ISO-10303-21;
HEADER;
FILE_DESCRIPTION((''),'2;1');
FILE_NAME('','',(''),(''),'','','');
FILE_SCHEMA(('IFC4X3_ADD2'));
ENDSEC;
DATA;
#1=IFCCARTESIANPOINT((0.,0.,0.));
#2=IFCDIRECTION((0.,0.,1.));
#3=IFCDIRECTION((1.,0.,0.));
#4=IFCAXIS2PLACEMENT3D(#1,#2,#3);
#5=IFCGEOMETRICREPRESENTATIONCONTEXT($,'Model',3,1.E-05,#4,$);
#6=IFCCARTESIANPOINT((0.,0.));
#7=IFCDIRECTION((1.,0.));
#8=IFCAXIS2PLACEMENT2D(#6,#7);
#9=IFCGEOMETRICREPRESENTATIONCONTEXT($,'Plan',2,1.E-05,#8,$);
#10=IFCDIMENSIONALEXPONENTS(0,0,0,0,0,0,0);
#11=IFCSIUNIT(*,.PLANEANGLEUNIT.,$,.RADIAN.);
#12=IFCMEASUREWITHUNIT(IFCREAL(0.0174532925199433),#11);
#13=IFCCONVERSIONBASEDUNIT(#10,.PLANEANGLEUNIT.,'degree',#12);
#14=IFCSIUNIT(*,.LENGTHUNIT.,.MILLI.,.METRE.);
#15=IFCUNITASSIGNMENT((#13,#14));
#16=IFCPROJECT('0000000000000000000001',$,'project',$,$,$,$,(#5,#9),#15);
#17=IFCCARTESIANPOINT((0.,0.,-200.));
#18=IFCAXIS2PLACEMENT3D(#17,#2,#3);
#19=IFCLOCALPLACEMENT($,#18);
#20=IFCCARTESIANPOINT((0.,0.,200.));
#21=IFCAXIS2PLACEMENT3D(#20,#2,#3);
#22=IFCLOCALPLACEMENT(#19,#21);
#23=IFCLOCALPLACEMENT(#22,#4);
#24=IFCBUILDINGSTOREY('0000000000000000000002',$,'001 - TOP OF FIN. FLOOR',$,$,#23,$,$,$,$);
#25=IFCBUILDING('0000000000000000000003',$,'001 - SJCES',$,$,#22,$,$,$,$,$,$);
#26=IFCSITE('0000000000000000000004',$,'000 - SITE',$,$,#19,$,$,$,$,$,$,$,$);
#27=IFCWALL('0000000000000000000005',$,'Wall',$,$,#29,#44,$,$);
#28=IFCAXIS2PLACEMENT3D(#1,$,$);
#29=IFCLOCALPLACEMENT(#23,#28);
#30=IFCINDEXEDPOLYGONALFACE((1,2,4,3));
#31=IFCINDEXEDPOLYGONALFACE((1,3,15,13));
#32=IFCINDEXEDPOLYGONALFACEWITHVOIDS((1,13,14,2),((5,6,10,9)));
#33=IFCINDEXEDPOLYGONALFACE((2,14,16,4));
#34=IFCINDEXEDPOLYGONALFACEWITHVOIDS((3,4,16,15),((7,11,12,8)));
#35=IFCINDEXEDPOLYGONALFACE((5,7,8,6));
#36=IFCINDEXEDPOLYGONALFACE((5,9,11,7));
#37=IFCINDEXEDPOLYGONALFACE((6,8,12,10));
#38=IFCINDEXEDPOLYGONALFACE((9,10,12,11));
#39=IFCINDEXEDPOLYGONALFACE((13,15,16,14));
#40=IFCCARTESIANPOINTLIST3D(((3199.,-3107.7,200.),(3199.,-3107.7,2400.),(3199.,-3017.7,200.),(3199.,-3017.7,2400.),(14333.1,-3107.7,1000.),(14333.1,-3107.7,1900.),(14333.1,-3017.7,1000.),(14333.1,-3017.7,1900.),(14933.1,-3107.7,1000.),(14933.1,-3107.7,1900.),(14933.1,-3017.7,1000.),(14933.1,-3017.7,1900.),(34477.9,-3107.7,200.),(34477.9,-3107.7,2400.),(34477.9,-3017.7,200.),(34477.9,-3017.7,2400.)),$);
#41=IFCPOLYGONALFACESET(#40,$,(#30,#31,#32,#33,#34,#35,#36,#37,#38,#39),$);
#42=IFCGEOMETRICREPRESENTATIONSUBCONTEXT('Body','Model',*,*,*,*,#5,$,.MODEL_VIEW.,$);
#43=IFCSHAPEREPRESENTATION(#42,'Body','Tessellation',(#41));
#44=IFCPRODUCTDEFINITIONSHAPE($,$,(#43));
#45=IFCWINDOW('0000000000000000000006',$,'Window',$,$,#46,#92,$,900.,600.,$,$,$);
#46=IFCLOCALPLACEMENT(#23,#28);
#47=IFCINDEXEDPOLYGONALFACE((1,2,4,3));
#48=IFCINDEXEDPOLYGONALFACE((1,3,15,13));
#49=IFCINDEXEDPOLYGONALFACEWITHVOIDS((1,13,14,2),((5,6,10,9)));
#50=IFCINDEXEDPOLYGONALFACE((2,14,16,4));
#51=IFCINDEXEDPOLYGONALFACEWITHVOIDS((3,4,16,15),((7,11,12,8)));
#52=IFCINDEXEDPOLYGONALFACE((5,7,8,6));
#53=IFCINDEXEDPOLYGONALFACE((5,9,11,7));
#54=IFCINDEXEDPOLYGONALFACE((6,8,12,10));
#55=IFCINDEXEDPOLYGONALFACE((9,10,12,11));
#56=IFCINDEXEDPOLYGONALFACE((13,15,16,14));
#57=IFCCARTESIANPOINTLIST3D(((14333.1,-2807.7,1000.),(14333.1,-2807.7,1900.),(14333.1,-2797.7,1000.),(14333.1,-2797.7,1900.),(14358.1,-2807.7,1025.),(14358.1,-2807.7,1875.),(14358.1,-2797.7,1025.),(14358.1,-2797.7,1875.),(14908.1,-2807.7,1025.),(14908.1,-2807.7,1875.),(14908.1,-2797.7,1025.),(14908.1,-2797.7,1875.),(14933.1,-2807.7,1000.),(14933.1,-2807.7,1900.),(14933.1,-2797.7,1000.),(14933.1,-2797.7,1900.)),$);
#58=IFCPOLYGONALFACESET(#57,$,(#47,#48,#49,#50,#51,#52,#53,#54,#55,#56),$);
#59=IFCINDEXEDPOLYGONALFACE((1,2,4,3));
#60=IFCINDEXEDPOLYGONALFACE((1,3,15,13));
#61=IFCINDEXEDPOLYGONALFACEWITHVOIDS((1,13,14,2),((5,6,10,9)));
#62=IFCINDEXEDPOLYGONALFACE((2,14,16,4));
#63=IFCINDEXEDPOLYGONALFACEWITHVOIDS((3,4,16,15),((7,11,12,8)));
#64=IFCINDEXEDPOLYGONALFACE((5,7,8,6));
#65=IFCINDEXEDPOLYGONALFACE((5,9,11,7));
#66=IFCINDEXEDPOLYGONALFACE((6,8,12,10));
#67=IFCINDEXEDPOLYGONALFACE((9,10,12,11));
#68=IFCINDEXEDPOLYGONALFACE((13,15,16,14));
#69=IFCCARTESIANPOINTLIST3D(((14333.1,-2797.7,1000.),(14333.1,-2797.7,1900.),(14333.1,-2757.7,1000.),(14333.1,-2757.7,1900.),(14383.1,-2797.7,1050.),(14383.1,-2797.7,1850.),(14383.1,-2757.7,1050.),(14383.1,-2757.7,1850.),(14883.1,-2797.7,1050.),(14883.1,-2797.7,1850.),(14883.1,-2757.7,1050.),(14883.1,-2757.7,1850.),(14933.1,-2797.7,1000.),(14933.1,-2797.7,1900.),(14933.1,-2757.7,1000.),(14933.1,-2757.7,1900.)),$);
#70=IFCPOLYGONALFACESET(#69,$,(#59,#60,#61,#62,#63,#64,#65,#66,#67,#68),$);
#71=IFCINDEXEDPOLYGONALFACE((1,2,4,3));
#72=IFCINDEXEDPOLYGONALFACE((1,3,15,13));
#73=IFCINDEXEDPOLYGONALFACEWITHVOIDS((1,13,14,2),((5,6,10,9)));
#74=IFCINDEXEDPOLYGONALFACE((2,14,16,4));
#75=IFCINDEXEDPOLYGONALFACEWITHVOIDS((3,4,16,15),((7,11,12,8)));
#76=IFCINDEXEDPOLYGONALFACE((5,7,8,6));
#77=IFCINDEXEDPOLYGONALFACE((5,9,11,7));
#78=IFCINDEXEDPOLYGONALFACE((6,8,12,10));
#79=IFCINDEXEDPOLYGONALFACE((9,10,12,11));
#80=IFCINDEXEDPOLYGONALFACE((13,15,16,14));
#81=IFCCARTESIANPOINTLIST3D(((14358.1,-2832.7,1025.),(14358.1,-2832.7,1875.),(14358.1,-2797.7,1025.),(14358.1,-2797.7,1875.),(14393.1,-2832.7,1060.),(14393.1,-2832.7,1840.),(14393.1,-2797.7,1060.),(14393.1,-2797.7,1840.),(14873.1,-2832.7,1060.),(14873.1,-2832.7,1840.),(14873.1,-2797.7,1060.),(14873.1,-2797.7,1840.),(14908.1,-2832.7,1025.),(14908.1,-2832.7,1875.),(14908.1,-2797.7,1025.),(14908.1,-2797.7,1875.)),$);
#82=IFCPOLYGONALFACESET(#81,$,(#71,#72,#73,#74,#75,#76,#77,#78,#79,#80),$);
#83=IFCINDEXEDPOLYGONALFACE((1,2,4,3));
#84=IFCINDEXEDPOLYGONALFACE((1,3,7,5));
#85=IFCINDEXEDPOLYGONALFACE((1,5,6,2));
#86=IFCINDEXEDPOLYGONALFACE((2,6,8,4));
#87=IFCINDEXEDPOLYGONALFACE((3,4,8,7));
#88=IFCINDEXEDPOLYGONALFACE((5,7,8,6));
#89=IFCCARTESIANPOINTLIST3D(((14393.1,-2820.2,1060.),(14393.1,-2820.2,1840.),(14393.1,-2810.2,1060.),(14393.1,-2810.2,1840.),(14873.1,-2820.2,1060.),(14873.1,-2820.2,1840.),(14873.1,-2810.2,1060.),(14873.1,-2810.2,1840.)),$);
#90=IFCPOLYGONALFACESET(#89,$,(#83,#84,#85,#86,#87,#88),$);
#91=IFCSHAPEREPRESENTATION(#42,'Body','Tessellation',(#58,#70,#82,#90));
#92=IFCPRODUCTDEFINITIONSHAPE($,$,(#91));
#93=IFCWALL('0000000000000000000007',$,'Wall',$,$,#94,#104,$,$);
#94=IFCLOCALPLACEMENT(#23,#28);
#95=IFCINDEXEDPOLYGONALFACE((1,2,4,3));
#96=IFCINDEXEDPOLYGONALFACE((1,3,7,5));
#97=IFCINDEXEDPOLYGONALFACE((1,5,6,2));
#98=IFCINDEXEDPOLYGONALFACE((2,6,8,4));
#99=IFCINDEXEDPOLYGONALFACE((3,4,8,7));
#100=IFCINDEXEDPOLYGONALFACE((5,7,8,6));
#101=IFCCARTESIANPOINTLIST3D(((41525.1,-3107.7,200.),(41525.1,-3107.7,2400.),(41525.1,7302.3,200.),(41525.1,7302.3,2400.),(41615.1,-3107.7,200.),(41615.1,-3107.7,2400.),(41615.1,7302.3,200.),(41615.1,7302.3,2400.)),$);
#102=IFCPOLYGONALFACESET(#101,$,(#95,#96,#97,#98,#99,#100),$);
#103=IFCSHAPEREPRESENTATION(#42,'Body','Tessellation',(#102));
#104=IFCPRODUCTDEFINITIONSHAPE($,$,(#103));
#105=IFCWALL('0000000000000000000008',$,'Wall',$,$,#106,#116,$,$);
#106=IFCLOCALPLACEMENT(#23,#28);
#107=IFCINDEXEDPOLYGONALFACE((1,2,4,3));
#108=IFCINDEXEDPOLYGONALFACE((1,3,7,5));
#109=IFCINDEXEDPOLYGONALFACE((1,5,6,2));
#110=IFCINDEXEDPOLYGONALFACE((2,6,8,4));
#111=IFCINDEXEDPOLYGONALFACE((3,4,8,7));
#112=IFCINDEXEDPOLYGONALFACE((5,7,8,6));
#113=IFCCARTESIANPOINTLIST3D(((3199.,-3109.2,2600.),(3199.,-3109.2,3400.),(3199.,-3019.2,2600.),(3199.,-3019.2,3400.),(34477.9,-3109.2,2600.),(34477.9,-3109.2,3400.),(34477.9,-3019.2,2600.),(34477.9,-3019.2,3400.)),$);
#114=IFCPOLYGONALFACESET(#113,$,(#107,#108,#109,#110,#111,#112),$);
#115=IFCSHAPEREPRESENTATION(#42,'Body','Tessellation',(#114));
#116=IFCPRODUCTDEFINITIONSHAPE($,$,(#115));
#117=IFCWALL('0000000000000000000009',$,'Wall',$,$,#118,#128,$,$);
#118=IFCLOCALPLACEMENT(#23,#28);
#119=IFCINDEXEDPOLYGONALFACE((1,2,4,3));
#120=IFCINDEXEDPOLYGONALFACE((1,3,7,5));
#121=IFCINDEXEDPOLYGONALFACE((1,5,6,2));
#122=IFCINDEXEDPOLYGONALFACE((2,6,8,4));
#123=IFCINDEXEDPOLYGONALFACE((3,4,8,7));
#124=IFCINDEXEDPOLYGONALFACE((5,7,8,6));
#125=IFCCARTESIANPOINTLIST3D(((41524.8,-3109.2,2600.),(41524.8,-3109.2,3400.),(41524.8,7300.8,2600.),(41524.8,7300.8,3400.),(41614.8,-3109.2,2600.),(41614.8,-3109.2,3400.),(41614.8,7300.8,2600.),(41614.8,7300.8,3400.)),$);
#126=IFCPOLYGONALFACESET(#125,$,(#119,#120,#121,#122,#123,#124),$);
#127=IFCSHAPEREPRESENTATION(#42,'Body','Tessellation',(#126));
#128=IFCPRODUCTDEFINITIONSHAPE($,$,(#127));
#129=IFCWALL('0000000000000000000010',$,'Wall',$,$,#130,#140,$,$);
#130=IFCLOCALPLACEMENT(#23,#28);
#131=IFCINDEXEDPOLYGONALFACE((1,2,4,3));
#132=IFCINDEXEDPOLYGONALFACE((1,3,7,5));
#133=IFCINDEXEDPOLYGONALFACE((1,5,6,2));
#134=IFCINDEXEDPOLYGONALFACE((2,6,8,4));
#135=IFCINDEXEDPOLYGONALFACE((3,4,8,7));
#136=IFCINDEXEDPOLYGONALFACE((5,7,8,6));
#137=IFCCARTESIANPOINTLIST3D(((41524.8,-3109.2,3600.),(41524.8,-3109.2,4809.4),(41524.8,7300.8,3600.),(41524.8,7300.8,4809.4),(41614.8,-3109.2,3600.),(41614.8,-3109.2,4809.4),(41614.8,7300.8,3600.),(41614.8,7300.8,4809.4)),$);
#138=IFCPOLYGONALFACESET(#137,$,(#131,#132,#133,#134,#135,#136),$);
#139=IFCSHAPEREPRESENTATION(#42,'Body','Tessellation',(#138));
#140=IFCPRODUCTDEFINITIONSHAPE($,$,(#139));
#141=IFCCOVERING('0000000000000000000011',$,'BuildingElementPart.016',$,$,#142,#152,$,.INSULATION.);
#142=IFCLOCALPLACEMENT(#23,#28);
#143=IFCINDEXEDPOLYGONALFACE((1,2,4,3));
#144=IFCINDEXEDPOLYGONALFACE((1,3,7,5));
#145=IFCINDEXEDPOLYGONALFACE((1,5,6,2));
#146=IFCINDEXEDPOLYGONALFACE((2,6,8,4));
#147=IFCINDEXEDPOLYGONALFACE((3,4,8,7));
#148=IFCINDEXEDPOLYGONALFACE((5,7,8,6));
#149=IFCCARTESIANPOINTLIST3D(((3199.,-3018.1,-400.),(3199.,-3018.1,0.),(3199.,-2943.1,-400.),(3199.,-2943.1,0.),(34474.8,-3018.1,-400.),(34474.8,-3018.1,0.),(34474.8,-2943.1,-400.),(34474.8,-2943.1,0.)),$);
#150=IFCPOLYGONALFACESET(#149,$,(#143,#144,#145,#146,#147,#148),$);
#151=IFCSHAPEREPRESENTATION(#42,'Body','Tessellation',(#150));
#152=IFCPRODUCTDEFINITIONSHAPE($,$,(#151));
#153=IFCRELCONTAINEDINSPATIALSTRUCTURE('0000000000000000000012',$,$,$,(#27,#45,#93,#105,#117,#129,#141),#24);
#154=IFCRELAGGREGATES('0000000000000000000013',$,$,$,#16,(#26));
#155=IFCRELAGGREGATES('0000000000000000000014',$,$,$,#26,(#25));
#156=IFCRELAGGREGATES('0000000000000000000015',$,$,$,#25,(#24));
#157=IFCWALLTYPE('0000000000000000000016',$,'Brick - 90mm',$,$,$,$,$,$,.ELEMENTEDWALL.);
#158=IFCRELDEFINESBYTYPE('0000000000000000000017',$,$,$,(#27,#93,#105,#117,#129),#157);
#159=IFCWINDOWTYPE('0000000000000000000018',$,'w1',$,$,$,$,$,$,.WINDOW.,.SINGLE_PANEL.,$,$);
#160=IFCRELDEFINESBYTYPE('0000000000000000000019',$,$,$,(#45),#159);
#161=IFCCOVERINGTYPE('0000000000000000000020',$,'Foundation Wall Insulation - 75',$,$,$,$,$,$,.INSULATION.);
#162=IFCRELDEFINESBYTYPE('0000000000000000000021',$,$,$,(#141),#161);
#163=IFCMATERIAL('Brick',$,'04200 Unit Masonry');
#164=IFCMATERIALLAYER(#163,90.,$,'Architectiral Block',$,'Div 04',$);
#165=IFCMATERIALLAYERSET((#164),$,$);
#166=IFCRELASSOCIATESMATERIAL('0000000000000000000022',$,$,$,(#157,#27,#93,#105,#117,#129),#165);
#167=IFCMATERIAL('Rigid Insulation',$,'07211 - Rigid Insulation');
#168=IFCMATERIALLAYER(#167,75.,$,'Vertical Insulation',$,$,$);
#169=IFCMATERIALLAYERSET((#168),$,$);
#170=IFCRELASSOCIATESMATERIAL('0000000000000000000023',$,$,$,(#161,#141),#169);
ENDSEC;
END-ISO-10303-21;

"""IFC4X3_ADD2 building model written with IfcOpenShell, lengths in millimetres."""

from ifc_helpers import new_model, entity, si_unit, converted_unit, frame, origin_with_axes, origin_2d_with_axis, place, context, subcontext, project, spatial, line, indexed_curve, outline, extrude, shape, source, transform, mapped, material, layer, layer_set, layer_usage, type_object, type_shapes, element, fill, save


model = new_model("IFC4X3_ADD2")

# Units and contexts
model_context = context("Model", 3, precision=1e-05, world=origin_with_axes())
plan_context = context("Plan", 2, precision=1e-05, world=origin_2d_with_axis())
body_context_1 = subcontext(model_context, "Body", "Model", "MODEL_VIEW")
body_context_2 = subcontext(plan_context, "Body", "Plan", "PLAN_VIEW")
ifc_project = project(units=[converted_unit("PLANEANGLEUNIT", "degree", entity("IfcReal", 0.0174532925199433), si_unit("PLANEANGLEUNIT", "RADIAN"), dimensions=[0, 0, 0, 0, 0, 0, 0]), si_unit("LENGTHUNIT", "METRE", prefix="MILLI")], contexts=[model_context, plan_context])

# Site, building, storey
site_placement = place(None, frame((0.0, 0.0, -200.0), z_axis=(0.0, 0.0, 1.0), x_axis=(1.0, 0.0, 0.0)))
site = spatial("IfcSite", under=ifc_project, at=site_placement, Name="000 - SITE")
building_placement = place(site_placement, frame((0.0, 0.0, 200.0), z_axis=(0.0, 0.0, 1.0), x_axis=(1.0, 0.0, 0.0)))
building = spatial("IfcBuilding", under=site, at=building_placement, Name="001 - SJCES")
storey_placement = place(building_placement, origin_with_axes())
storey = spatial("IfcBuildingStorey", under=building, at=storey_placement, Name="001 - TOP OF FIN. FLOOR")

# Wall, openings, window
ifc_material_1 = material(Name="Brick", Category="04200 Unit Masonry")
ifc_layer_1 = layer(ifc_material_1, 90.0, Name="Architectiral Block", Category="Div 04")
ifc_layer_set_1 = layer_set([ifc_layer_1])
ifc_layer_usage_1 = layer_usage(ifc_layer_set_1, "AXIS2", "POSITIVE", 0.0)
wall_type_1 = type_object("IfcWallType", Name="Brick - 90mm", PredefinedType="ELEMENTEDWALL", material=ifc_layer_set_1)
wall_1_placement = place(storey_placement, frame((3199.0, -3107.7, 200.0), z_axis=(0.0, 0.0, 1.0), x_axis=(1.0, 0.0, 0.0)))
wall_1 = element("IfcWall", 1, at=wall_1_placement, inside=storey, type_object=wall_type_1, material=ifc_layer_usage_1, Name="Wall", context=body_context_1, shape_type="SweptSolid", body=[
    extrude(outline(indexed_curve([(0.0, 0.0), (0.0, 90.0), (31278.9, 90.0), (31278.9, 0.0), (0.0, 0.0)], self_intersect=False)), origin_with_axes(), (0.0, 0.0, 1.0), 2200.0),
])
shared_shape_1 = source(origin_with_axes(), body_context_1, "Body", "SweptSolid", [
    extrude(outline(indexed_curve([(0.0, 0.0), (600.0, 0.0), (600.0, 900.0), (0.0, 900.0)], segments=[line(1, 2, 3, 4, 1)])), frame((0.0, -600.0, 0.0), z_axis=(0.0, -1.0, 0.0), x_axis=(1.0, 0.0, 0.0)), (0.0, 0.0, -1.0), 1200.0),
])
opening_1_placement = place(wall_1_placement, frame((11734.1, 400.0, 800.0), z_axis=(0.0, 0.0, 1.0), x_axis=(-1.0, 0.0, 0.0)))
opening_1 = element("IfcOpeningElement", 2, at=opening_1_placement, cuts=wall_1, PredefinedType="OPENING", context=body_context_1, shape_type="MappedRepresentation", body=[
    mapped(shared_shape_1, transform((0.0, 0.0, 0.0), x_axis=(1.0, 0.0, 0.0), y_axis=(0.0, 1.0, 0.0), z_axis=(0.0, 0.0, 1.0), scale=1.0)),
])
covering_1_placement = place(storey_placement, frame((34562.0, -2897.7, 0.0), z_axis=(0.0, 0.0, 1.0), x_axis=(-1.0, 0.0, 0.0)))
opening_2_placement = place(covering_1_placement, frame((19628.9, -190.0, 1000.0), z_axis=(0.0, 0.0, 1.0), x_axis=(1.0, 0.0, 0.0)))
element("IfcOpeningElement", 3, at=opening_2_placement, cuts=wall_1, context=body_context_1, shape_type="MappedRepresentation", body=[
    mapped(shared_shape_1, transform((0.0, 0.0, 0.0), x_axis=(1.0, 0.0, 0.0), y_axis=(0.0, 1.0, 0.0), z_axis=(0.0, 0.0, 1.0), scale=1.0)),
])
window_type = type_object("IfcWindowType", Name="w1", PartitioningType="SINGLE_PANEL", PredefinedType="WINDOW")
shared_shape_2 = source(origin_with_axes(), body_context_1, "Body", "SweptSolid", [
    extrude(outline(indexed_curve([(0.0, 0.0), (600.0, 0.0), (600.0, 900.0), (0.0, 900.0)], segments=[line(1, 2, 3, 4, 1)]), holes=[indexed_curve([(25.0, 25.0), (575.0, 25.0), (575.0, 875.0), (25.0, 875.0)], segments=[line(1, 2, 3, 4, 1)])]), frame((0.0, 90.0, 0.0), z_axis=(0.0, -1.0, 0.0), x_axis=(1.0, 0.0, 0.0)), (0.0, 0.0, -1.0), 10.0),
    extrude(outline(indexed_curve([(0.0, 0.0), (600.0, 0.0), (600.0, 900.0), (0.0, 900.0)], segments=[line(1, 2, 3, 4, 1)]), holes=[indexed_curve([(50.0, 50.0), (550.0, 50.0), (550.0, 850.0), (50.0, 850.0)], segments=[line(1, 2, 3, 4, 1)])]), frame((0.0, 50.0, 0.0), z_axis=(0.0, -1.0, 0.0), x_axis=(1.0, 0.0, 0.0)), (0.0, 0.0, -1.0), 40.0),
    extrude(outline(indexed_curve([(0.0, 0.0), (550.0, 0.0), (550.0, 850.0), (0.0, 850.0)], segments=[line(1, 2, 3, 4, 1)]), holes=[indexed_curve([(35.0, 35.0), (515.0, 35.0), (515.0, 815.0), (35.0, 815.0)], segments=[line(1, 2, 3, 4, 1)])]), frame((25.0, 90.0, 25.0), z_axis=(0.0, -1.0, 0.0), x_axis=(1.0, 0.0, 0.0)), (0.0, 0.0, -1.0), 35.0),
    extrude(outline(indexed_curve([(35.0, 35.0), (515.0, 35.0), (515.0, 815.0), (35.0, 815.0)], segments=[line(1, 2, 3, 4, 1)])), frame((25.0, 102.5, 25.0), z_axis=(0.0, -1.0, 0.0), x_axis=(1.0, 0.0, 0.0)), (0.0, 0.0, -1.0), 10.0),
])
shared_shape_3 = source(origin_with_axes(), body_context_2, "Body", "Curve2D", [
    entity("IfcIndexedPolyCurve", entity("IfcCartesianPointList2D", [[50.0, 50.0], [550.0, 50.0]])),
    entity("IfcIndexedPolyCurve", entity("IfcCartesianPointList2D", [[0.0, 100.0], [25.0, 100.0], [25.0, 90.0], [50.0, 90.0], [50.0, 50.0], [0.0, 50.0]]), [entity("IfcLineIndex", [1, 2, 3, 4, 5, 6, 1])]),
    entity("IfcIndexedPolyCurve", entity("IfcCartesianPointList2D", [[600.0, 100.0], [575.0, 100.0], [575.0, 90.0], [550.0, 90.0], [550.0, 50.0], [600.0, 50.0]]), [entity("IfcLineIndex", [1, 2, 3, 4, 5, 6, 1])]),
    entity("IfcIndexedPolyCurve", entity("IfcCartesianPointList2D", [[25.0, 90.0], [60.0, 90.0], [60.0, 125.0], [25.0, 125.0]]), [entity("IfcLineIndex", [1, 2, 3, 4, 1])]),
    entity("IfcIndexedPolyCurve", entity("IfcCartesianPointList2D", [[575.0, 90.0], [540.0, 90.0], [540.0, 125.0], [575.0, 125.0]]), [entity("IfcLineIndex", [1, 2, 3, 4, 1])]),
    entity("IfcIndexedPolyCurve", entity("IfcCartesianPointList2D", [[60.0, 90.0], [540.0, 90.0]])),
    entity("IfcIndexedPolyCurve", entity("IfcCartesianPointList2D", [[60.0, 125.0], [540.0, 125.0]])),
    entity("IfcIndexedPolyCurve", entity("IfcCartesianPointList2D", [[60.0, 107.5], [540.0, 107.5]])),
])
type_shapes(window_type, [shared_shape_2, shared_shape_3])
window_placement = place(opening_1_placement, frame((0.0, 0.0, 0.0), z_axis=(0.0, 0.0, 1.0), x_axis=(1.0, 0.0, 0.0)))
window = element("IfcWindow", 4, at=window_placement, inside=storey, type_object=window_type, Name="Window", OverallHeight=900.0, OverallWidth=600.0, shapes=[
    shape(body_context_1, "Body", "MappedRepresentation", [mapped(shared_shape_2, transform((0.0, 0.0, 0.0), x_axis=(1.0, 0.0, 0.0), y_axis=(0.0, 1.0, 0.0), z_axis=(0.0, 0.0, 1.0), scale=1.0))]),
    shape(body_context_2, "Body", "MappedRepresentation", [mapped(shared_shape_3, transform((0.0, 0.0, 0.0), x_axis=(1.0, 0.0, 0.0), y_axis=(0.0, 1.0, 0.0), z_axis=(0.0, 0.0, 1.0), scale=1.0))]),
])
fill(opening_1, window)

# Walls
ifc_layer_usage_2 = layer_usage(ifc_layer_set_1, "AXIS2", "POSITIVE", 0.0)
wall_2_placement = place(storey_placement, frame((41615.1, -3107.7, 200.0), z_axis=(0.0, 0.0, 1.0), x_axis=(0.0, 1.0, 0.0)))
element("IfcWall", 5, at=wall_2_placement, inside=storey, type_object=wall_type_1, material=ifc_layer_usage_2, Name="Wall", context=body_context_1, shape_type="SweptSolid", body=[
    extrude(outline(indexed_curve([(0.0, 0.0), (0.0, 90.0), (10410.0, 90.0), (10410.0, 0.0), (0.0, 0.0)], self_intersect=False)), origin_with_axes(), (0.0, 0.0, 1.0), 2200.0),
])
ifc_layer_usage_3 = layer_usage(ifc_layer_set_1, "AXIS2", "POSITIVE", 0.0)
wall_3_placement = place(storey_placement, frame((3199.0, -3109.2, 2600.0), z_axis=(0.0, 0.0, 1.0), x_axis=(1.0, 0.0, 0.0)))
element("IfcWall", 6, at=wall_3_placement, inside=storey, type_object=wall_type_1, material=ifc_layer_usage_3, Name="Wall", context=body_context_1, shape_type="SweptSolid", body=[
    extrude(outline(indexed_curve([(0.0, 0.0), (0.0, 90.0), (31278.9, 90.0), (31278.9, 0.0), (0.0, 0.0)], self_intersect=False)), origin_with_axes(), (0.0, 0.0, 1.0), 800.0),
])
ifc_layer_usage_4 = layer_usage(ifc_layer_set_1, "AXIS2", "POSITIVE", 0.0)
wall_4_placement = place(storey_placement, frame((41614.8, -3109.2, 2600.0), z_axis=(0.0, 0.0, 1.0), x_axis=(0.0, 1.0, 0.0)))
element("IfcWall", 7, at=wall_4_placement, inside=storey, type_object=wall_type_1, material=ifc_layer_usage_4, Name="Wall", context=body_context_1, shape_type="SweptSolid", body=[
    extrude(outline(indexed_curve([(0.0, 0.0), (0.0, 90.0), (10410.0, 90.0), (10410.0, 0.0), (0.0, 0.0)], self_intersect=False)), origin_with_axes(), (0.0, 0.0, 1.0), 800.0),
])
ifc_layer_usage_5 = layer_usage(ifc_layer_set_1, "AXIS2", "POSITIVE", 0.0)
wall_5_placement = place(storey_placement, frame((41614.8, -3109.2, 3600.0), z_axis=(0.0, 0.0, 1.0), x_axis=(0.0, 1.0, 0.0)))
element("IfcWall", 8, at=wall_5_placement, inside=storey, type_object=wall_type_1, material=ifc_layer_usage_5, Name="Wall", context=body_context_1, shape_type="SweptSolid", body=[
    extrude(outline(indexed_curve([(0.0, 0.0), (0.0, 90.0), (10410.0, 90.0), (10410.0, 0.0), (0.0, 0.0)], self_intersect=False)), origin_with_axes(), (0.0, 0.0, 1.0), 1209.4),
])

# Covering
ifc_material_2 = material(Name="Rigid Insulation", Category="07211 - Rigid Insulation")
ifc_layer_2 = layer(ifc_material_2, 75.0, Name="Vertical Insulation")
ifc_layer_set_2 = layer_set([ifc_layer_2])
ifc_layer_usage_6 = layer_usage(ifc_layer_set_2, "AXIS2", "POSITIVE", 0.0)
covering_type_1 = type_object("IfcCoveringType", Name="Foundation Wall Insulation - 75", PredefinedType="INSULATION", material=ifc_layer_set_2)
covering_2_placement = place(storey_placement, frame((3199.0, -3018.1, -400.0), z_axis=(0.0, 0.0, 1.0), x_axis=(1.0, 0.0, 0.0)))
element("IfcCovering", 9, at=covering_2_placement, inside=storey, type_object=covering_type_1, material=ifc_layer_usage_6, Name="BuildingElementPart.016", PredefinedType="INSULATION", context=body_context_1, shape_type="SweptSolid", body=[
    extrude(outline(indexed_curve([(0.0, 0.0), (0.0, 75.0), (31275.8, 75.0), (31275.8, 0.0), (0.0, 0.0)], self_intersect=False)), origin_with_axes(), (0.0, 0.0, 1.0), 400.0),
])

save(model, "model.ifc")
